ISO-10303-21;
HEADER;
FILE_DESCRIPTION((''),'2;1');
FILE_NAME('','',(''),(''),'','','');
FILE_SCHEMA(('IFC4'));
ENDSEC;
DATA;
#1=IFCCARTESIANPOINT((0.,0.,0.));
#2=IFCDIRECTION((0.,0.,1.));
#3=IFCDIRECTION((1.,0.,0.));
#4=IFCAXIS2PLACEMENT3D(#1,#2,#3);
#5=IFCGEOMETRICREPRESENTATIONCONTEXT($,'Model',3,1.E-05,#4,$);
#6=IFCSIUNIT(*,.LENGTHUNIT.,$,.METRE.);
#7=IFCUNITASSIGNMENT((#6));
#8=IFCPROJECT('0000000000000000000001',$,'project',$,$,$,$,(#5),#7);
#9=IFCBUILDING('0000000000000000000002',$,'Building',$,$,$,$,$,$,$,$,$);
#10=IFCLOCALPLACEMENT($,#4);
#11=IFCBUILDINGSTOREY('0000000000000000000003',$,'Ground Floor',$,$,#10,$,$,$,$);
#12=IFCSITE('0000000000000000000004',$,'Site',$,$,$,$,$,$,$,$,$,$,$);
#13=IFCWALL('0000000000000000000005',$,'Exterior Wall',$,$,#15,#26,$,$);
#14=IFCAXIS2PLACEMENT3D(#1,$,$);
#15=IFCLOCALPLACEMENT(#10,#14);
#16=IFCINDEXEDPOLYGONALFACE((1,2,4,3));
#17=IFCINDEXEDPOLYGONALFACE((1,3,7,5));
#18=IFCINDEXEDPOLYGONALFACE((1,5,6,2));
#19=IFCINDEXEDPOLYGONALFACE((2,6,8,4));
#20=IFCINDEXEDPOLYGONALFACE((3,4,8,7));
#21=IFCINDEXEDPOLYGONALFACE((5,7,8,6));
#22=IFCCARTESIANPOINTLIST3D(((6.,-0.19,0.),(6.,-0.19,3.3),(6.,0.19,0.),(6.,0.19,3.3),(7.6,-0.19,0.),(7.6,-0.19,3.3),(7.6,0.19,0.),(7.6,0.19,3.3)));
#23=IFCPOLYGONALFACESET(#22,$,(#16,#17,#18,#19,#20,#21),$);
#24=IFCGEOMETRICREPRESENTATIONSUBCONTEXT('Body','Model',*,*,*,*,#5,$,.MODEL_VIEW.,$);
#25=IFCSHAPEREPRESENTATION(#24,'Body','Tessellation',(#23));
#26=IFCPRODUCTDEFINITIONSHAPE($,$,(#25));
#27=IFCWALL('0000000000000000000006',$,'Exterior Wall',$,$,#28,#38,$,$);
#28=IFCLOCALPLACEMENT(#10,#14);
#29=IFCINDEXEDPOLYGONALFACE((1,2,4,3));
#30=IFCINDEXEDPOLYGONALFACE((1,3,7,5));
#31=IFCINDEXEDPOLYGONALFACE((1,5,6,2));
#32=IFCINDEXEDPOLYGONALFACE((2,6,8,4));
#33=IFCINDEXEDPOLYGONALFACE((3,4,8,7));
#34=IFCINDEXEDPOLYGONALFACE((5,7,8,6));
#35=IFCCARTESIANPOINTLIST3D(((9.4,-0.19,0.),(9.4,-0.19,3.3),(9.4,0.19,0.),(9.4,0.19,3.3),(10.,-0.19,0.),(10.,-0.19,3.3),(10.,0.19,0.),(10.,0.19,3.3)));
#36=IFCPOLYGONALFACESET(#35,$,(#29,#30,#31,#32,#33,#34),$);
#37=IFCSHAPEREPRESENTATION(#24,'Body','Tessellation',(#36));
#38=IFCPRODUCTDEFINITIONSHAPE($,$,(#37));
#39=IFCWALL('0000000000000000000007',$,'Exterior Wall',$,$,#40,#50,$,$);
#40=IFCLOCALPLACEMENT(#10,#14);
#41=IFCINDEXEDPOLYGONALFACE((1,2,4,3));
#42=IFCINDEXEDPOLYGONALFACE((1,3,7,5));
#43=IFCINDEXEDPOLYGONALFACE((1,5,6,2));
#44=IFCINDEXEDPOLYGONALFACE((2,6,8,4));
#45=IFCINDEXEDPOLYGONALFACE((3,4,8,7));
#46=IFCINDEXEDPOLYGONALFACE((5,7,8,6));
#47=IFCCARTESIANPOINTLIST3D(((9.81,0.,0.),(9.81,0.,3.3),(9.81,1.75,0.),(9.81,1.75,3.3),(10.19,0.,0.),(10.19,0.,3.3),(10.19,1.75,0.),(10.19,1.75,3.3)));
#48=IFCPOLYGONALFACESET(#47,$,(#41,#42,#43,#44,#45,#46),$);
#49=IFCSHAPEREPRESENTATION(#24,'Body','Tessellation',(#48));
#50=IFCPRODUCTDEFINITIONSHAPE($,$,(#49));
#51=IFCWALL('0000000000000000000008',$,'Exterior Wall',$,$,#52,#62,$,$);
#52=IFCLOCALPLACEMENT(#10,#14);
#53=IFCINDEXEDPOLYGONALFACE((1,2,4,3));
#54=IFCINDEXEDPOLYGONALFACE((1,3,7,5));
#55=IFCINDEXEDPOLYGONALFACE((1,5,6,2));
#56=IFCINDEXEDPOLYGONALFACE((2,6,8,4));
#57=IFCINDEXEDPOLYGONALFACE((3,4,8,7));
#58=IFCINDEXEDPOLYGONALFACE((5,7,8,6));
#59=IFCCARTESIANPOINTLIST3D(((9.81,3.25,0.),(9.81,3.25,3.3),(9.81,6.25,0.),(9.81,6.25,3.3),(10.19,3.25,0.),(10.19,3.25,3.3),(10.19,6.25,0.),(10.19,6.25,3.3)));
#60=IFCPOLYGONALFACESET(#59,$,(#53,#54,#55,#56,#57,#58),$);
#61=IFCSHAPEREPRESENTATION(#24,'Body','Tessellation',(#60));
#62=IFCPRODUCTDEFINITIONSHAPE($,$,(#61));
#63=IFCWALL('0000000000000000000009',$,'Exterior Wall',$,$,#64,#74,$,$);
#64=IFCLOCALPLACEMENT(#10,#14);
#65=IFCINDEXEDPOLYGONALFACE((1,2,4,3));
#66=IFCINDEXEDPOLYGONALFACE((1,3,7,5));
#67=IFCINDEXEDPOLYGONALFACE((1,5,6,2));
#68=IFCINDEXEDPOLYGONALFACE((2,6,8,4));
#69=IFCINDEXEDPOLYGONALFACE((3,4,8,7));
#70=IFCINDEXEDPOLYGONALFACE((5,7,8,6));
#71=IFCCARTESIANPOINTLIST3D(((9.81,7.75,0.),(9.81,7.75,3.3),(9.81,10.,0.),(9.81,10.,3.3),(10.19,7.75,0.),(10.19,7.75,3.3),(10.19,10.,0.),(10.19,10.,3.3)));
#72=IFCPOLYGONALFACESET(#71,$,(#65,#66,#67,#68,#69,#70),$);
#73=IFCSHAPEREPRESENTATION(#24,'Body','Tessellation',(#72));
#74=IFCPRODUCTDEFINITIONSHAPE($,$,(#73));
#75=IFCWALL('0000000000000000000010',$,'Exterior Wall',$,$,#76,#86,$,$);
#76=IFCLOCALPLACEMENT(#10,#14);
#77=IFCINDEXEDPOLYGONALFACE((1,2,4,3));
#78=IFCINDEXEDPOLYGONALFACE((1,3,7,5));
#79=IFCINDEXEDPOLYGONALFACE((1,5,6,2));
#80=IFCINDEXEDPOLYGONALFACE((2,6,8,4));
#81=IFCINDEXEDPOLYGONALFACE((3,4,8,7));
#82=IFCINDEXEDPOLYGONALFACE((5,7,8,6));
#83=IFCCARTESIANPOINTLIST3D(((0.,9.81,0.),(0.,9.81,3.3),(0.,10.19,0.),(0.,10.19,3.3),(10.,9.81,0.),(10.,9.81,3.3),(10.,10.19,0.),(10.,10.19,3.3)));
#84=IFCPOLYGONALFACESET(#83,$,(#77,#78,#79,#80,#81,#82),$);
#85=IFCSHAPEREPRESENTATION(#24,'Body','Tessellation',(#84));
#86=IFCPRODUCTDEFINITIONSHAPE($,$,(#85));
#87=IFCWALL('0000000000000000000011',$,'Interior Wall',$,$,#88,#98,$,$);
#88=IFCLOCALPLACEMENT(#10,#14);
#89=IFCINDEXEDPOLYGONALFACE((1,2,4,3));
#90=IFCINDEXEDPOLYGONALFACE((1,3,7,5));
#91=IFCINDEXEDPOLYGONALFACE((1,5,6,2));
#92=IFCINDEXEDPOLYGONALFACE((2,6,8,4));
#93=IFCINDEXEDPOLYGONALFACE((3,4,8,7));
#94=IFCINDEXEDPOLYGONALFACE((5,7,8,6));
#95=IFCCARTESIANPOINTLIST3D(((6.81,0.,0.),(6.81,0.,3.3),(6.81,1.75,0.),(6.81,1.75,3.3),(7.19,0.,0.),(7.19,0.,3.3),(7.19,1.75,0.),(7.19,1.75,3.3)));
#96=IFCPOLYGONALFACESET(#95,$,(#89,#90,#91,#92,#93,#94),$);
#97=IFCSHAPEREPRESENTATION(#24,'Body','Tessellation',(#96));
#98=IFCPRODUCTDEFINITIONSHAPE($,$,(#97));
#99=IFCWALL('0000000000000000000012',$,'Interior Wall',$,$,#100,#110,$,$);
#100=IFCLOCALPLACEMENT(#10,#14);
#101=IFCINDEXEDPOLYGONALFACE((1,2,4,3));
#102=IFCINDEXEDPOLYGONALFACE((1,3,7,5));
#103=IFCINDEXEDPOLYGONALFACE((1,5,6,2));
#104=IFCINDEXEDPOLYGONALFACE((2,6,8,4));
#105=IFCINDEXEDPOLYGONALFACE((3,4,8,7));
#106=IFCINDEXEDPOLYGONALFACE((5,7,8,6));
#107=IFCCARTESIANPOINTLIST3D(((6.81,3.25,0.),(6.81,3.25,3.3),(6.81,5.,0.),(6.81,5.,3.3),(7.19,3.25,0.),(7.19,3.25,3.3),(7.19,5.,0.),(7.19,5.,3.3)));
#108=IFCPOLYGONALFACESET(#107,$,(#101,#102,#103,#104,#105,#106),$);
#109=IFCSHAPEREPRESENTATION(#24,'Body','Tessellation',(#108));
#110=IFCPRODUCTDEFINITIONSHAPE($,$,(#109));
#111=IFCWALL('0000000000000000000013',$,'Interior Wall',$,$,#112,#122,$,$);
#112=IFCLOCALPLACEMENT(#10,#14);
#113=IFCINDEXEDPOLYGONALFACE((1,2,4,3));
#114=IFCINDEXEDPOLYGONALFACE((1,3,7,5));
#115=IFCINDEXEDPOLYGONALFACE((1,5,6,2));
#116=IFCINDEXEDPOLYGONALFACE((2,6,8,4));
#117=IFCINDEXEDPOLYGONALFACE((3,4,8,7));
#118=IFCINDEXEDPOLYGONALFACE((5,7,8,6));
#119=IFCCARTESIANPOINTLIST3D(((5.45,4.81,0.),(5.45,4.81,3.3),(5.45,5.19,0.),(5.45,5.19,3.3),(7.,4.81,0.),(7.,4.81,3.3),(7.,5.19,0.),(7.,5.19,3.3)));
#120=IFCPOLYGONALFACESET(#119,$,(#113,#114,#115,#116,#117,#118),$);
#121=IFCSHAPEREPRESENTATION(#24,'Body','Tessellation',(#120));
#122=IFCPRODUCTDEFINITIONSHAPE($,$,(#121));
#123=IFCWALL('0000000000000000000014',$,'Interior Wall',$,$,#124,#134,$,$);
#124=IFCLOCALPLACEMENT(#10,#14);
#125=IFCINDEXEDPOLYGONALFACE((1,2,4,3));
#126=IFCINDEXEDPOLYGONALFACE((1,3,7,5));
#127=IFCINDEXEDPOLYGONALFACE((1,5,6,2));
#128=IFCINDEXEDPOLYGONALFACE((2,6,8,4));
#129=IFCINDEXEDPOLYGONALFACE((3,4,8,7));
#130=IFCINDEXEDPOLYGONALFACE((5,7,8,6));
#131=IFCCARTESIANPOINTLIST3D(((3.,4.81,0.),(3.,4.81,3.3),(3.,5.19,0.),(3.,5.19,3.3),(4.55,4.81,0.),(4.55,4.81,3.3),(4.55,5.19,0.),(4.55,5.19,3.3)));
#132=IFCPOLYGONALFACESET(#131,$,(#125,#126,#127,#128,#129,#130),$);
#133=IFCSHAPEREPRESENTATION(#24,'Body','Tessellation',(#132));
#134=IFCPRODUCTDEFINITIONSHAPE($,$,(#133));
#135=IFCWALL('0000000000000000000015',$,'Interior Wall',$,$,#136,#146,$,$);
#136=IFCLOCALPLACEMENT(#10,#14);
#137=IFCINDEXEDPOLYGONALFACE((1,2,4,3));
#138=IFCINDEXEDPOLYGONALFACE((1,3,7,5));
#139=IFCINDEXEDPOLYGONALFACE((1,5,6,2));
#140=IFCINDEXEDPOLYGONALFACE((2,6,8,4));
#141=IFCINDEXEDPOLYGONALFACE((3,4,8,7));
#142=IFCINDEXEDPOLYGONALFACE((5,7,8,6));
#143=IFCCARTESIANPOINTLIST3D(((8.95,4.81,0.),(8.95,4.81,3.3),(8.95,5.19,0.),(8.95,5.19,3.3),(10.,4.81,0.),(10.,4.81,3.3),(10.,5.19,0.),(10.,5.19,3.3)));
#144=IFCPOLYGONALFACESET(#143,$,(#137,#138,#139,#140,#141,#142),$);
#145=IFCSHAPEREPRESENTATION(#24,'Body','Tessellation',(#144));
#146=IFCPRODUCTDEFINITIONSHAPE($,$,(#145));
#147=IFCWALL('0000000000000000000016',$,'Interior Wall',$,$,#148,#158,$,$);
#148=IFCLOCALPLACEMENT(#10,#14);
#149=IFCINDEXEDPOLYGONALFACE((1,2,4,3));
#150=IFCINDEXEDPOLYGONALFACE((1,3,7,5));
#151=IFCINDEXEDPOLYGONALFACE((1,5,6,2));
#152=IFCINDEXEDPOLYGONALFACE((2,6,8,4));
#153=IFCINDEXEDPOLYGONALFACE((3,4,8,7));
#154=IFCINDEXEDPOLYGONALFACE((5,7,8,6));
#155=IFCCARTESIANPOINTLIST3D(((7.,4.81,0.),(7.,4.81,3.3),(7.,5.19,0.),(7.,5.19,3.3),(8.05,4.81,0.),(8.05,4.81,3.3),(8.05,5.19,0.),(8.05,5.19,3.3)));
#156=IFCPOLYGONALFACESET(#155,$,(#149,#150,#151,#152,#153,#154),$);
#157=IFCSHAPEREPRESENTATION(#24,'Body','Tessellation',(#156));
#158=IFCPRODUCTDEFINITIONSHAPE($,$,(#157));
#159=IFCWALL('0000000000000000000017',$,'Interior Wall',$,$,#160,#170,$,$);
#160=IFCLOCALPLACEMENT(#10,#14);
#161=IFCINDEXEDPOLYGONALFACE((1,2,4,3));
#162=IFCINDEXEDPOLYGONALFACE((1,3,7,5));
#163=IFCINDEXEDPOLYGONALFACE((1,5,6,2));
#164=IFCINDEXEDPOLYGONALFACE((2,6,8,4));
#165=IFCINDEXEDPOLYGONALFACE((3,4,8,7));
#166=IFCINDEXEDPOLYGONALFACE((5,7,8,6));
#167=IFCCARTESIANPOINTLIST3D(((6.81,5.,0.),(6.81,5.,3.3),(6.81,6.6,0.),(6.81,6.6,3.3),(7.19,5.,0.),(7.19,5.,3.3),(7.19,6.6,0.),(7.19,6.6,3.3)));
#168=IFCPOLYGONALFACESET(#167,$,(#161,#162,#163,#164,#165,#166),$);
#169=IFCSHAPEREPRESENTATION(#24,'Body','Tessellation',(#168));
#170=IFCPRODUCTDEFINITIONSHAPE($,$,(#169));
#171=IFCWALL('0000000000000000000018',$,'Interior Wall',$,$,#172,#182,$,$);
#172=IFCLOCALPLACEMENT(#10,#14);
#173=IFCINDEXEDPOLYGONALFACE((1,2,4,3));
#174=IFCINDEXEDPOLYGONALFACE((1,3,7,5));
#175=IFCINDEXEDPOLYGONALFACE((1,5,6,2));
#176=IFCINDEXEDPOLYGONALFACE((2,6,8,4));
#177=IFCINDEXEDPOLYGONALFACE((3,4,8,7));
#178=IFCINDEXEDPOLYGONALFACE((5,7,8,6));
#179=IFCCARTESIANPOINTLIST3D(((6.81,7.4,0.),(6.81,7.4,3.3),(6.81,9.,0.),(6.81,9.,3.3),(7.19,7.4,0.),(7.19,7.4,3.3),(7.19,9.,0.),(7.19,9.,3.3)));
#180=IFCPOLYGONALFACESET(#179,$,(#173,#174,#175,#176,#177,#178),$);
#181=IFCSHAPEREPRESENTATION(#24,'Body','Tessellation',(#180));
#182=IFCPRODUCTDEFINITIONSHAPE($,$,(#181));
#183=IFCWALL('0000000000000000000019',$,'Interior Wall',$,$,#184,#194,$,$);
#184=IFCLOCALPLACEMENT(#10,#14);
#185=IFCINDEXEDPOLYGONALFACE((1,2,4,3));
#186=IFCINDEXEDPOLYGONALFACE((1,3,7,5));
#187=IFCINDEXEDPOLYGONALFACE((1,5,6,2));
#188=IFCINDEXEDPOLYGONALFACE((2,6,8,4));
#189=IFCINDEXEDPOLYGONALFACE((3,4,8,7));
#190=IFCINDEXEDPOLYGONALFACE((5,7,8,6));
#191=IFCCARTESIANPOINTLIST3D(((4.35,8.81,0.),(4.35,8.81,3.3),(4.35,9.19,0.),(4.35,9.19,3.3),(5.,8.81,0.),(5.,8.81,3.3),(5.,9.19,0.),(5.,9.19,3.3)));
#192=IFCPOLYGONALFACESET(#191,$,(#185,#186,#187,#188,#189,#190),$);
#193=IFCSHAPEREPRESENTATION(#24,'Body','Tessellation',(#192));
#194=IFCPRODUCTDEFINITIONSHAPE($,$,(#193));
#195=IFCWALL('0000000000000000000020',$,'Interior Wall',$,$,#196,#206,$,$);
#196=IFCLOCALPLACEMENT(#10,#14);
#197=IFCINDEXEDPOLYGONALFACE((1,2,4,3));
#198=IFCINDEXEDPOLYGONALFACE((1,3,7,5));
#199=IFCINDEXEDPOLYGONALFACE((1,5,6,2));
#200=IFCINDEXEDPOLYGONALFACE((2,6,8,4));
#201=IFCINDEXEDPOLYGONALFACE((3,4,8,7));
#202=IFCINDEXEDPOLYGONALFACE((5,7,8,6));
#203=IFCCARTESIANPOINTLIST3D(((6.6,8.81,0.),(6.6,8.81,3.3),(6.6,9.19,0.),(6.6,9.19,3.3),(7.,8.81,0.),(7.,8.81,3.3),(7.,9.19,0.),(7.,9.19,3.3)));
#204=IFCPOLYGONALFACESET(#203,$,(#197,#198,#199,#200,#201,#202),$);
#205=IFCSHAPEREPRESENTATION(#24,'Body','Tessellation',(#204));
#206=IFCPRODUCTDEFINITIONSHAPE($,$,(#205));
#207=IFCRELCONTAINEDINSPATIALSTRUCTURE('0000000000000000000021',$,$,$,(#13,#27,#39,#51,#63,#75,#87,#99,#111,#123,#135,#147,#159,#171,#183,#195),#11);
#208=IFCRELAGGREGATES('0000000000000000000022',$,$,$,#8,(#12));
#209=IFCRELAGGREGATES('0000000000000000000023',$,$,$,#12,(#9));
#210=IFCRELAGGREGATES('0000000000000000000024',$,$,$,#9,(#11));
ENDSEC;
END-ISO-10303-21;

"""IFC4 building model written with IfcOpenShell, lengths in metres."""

from ifc_helpers import new_model, si_unit, frame, origin_with_axes, place, context, subcontext, project, spatial, indexed_curve, outline, extrude, element, save


model = new_model("IFC4")

# Units and contexts
model_context = context("Model", 3, precision=1e-05, world=origin_with_axes())
body_context = subcontext(model_context, "Body", "Model", "MODEL_VIEW")
ifc_project = project(units=[si_unit("LENGTHUNIT", "METRE")], contexts=[model_context])

# Site, building, storey
site = spatial("IfcSite", under=ifc_project, Name="Site")
building = spatial("IfcBuilding", under=site, Name="Building")
storey_placement = place(None, origin_with_axes())
storey = spatial("IfcBuildingStorey", under=building, at=storey_placement, Name="Ground Floor")

# Walls
wall_1_placement = place(storey_placement, frame((6.0, 0.0, 0.0), z_axis=(0.0, 0.0, 1.0), x_axis=(1.0, 0.0, 0.0)))
element("IfcWall", 1, at=wall_1_placement, inside=storey, Name="Exterior Wall", context=body_context, shape_type="SweptSolid", body=[
    extrude(outline(indexed_curve([(0.0, 0.0), (0.0, 0.38), (1.6, 0.38), (1.6, 0.0), (0.0, 0.0)], self_intersect=False)), frame((0.0, -0.19, 0.0), z_axis=(0.0, 0.0, 1.0), x_axis=(1.0, 0.0, 0.0)), (0.0, 0.0, 1.0), 3.3),
])
wall_2_placement = place(storey_placement, frame((9.4, 0.0, 0.0), z_axis=(0.0, 0.0, 1.0), x_axis=(1.0, 0.0, 0.0)))
element("IfcWall", 2, at=wall_2_placement, inside=storey, Name="Exterior Wall", context=body_context, shape_type="SweptSolid", body=[
    extrude(outline(indexed_curve([(0.0, 0.0), (0.0, 0.38), (0.6, 0.38), (0.6, 0.0), (0.0, 0.0)], self_intersect=False)), frame((0.0, -0.19, 0.0), z_axis=(0.0, 0.0, 1.0), x_axis=(1.0, 0.0, 0.0)), (0.0, 0.0, 1.0), 3.3),
])
wall_3_placement = place(storey_placement, frame((10.0, 0.0, 0.0), z_axis=(0.0, 0.0, 1.0), x_axis=(0.0, 1.0, 0.0)))
element("IfcWall", 3, at=wall_3_placement, inside=storey, Name="Exterior Wall", context=body_context, shape_type="SweptSolid", body=[
    extrude(outline(indexed_curve([(0.0, 0.0), (0.0, 0.38), (1.75, 0.38), (1.75, 0.0), (0.0, 0.0)], self_intersect=False)), frame((0.0, -0.19, 0.0), z_axis=(0.0, 0.0, 1.0), x_axis=(1.0, 0.0, 0.0)), (0.0, 0.0, 1.0), 3.3),
])
wall_4_placement = place(storey_placement, frame((10.0, 3.25, 0.0), z_axis=(0.0, 0.0, 1.0), x_axis=(0.0, 1.0, 0.0)))
element("IfcWall", 4, at=wall_4_placement, inside=storey, Name="Exterior Wall", context=body_context, shape_type="SweptSolid", body=[
    extrude(outline(indexed_curve([(0.0, 0.0), (0.0, 0.38), (3.0, 0.38), (3.0, 0.0), (0.0, 0.0)], self_intersect=False)), frame((0.0, -0.19, 0.0), z_axis=(0.0, 0.0, 1.0), x_axis=(1.0, 0.0, 0.0)), (0.0, 0.0, 1.0), 3.3),
])
wall_5_placement = place(storey_placement, frame((10.0, 7.75, 0.0), z_axis=(0.0, 0.0, 1.0), x_axis=(0.0, 1.0, 0.0)))
element("IfcWall", 5, at=wall_5_placement, inside=storey, Name="Exterior Wall", context=body_context, shape_type="SweptSolid", body=[
    extrude(outline(indexed_curve([(0.0, 0.0), (0.0, 0.38), (2.25, 0.38), (2.25, 0.0), (0.0, 0.0)], self_intersect=False)), frame((0.0, -0.19, 0.0), z_axis=(0.0, 0.0, 1.0), x_axis=(1.0, 0.0, 0.0)), (0.0, 0.0, 1.0), 3.3),
])
wall_6_placement = place(storey_placement, frame((10.0, 10.0, 0.0), z_axis=(0.0, 0.0, 1.0), x_axis=(-1.0, 0.0, 0.0)))
element("IfcWall", 6, at=wall_6_placement, inside=storey, Name="Exterior Wall", context=body_context, shape_type="SweptSolid", body=[
    extrude(outline(indexed_curve([(0.0, 0.0), (0.0, 0.38), (10.0, 0.38), (10.0, 0.0), (0.0, 0.0)], self_intersect=False)), frame((0.0, -0.19, 0.0), z_axis=(0.0, 0.0, 1.0), x_axis=(1.0, 0.0, 0.0)), (0.0, 0.0, 1.0), 3.3),
])
for number, where, z_axis, x_axis, name in (
    (7, (7.0, 0.0, 0.0), (0.0, 0.0, 1.0), (0.0, 1.0, 0.0), "Interior Wall"),
    (8, (7.0, 3.25, 0.0), (0.0, 0.0, 1.0), (0.0, 1.0, 0.0), "Interior Wall"),
):
    element("IfcWall", number, at=place(storey_placement, frame(where, z_axis=z_axis, x_axis=x_axis)), inside=storey, Name=name, context=body_context, shape_type="SweptSolid", body=[
        extrude(outline(indexed_curve([(0.0, 0.0), (0.0, 0.38), (1.75, 0.38), (1.75, 0.0), (0.0, 0.0)], self_intersect=False)), frame((0.0, -0.19, 0.0), z_axis=(0.0, 0.0, 1.0), x_axis=(1.0, 0.0, 0.0)), (0.0, 0.0, 1.0), 3.3),
    ])
for number, where, z_axis, x_axis, name in (
    (9, (7.0, 5.0, 0.0), (0.0, 0.0, 1.0), (-1.0, 0.0, 0.0), "Interior Wall"),
    (10, (4.55, 5.0, 0.0), (0.0, 0.0, 1.0), (-1.0, 0.0, 0.0), "Interior Wall"),
):
    element("IfcWall", number, at=place(storey_placement, frame(where, z_axis=z_axis, x_axis=x_axis)), inside=storey, Name=name, context=body_context, shape_type="SweptSolid", body=[
        extrude(outline(indexed_curve([(0.0, 0.0), (0.0, 0.38), (1.55, 0.38), (1.55, 0.0), (0.0, 0.0)], self_intersect=False)), frame((0.0, -0.19, 0.0), z_axis=(0.0, 0.0, 1.0), x_axis=(1.0, 0.0, 0.0)), (0.0, 0.0, 1.0), 3.3),
    ])
for number, where, z_axis, x_axis, name in (
    (11, (10.0, 5.0, 0.0), (0.0, 0.0, 1.0), (-1.0, 0.0, 0.0), "Interior Wall"),
    (12, (8.05, 5.0, 0.0), (0.0, 0.0, 1.0), (-1.0, 0.0, 0.0), "Interior Wall"),
):
    element("IfcWall", number, at=place(storey_placement, frame(where, z_axis=z_axis, x_axis=x_axis)), inside=storey, Name=name, context=body_context, shape_type="SweptSolid", body=[
        extrude(outline(indexed_curve([(0.0, 0.0), (0.0, 0.38), (1.05, 0.38), (1.05, 0.0), (0.0, 0.0)], self_intersect=False)), frame((0.0, -0.19, 0.0), z_axis=(0.0, 0.0, 1.0), x_axis=(1.0, 0.0, 0.0)), (0.0, 0.0, 1.0), 3.3),
    ])
for number, where, z_axis, x_axis, name in (
    (13, (7.0, 5.0, 0.0), (0.0, 0.0, 1.0), (0.0, 1.0, 0.0), "Interior Wall"),
    (14, (7.0, 7.4, 0.0), (0.0, 0.0, 1.0), (0.0, 1.0, 0.0), "Interior Wall"),
):
    element("IfcWall", number, at=place(storey_placement, frame(where, z_axis=z_axis, x_axis=x_axis)), inside=storey, Name=name, context=body_context, shape_type="SweptSolid", body=[
        extrude(outline(indexed_curve([(0.0, 0.0), (0.0, 0.38), (1.6, 0.38), (1.6, 0.0), (0.0, 0.0)], self_intersect=False)), frame((0.0, -0.19, 0.0), z_axis=(0.0, 0.0, 1.0), x_axis=(1.0, 0.0, 0.0)), (0.0, 0.0, 1.0), 3.3),
    ])
wall_7_placement = place(storey_placement, frame((5.0, 9.0, 0.0), z_axis=(0.0, 0.0, 1.0), x_axis=(-1.0, 0.0, 0.0)))
element("IfcWall", 15, at=wall_7_placement, inside=storey, Name="Interior Wall", context=body_context, shape_type="SweptSolid", body=[
    extrude(outline(indexed_curve([(0.0, 0.0), (0.0, 0.38), (0.65, 0.38), (0.65, 0.0), (0.0, 0.0)], self_intersect=False)), frame((0.0, -0.19, 0.0), z_axis=(0.0, 0.0, 1.0), x_axis=(1.0, 0.0, 0.0)), (0.0, 0.0, 1.0), 3.3),
])
for number, where, z_axis, x_axis, name in (
    (16, (7.0, 9.0, 0.0), (0.0, 0.0, 1.0), (-1.0, 0.0, 0.0), "Interior Wall"),
):
    element("IfcWall", number, at=place(storey_placement, frame(where, z_axis=z_axis, x_axis=x_axis)), inside=storey, Name=name, context=body_context, shape_type="SweptSolid", body=[
        extrude(outline(indexed_curve([(0.0, 0.0), (0.0, 0.38), (0.4, 0.38), (0.4, 0.0), (0.0, 0.0)], self_intersect=False)), frame((0.0, -0.19, 0.0), z_axis=(0.0, 0.0, 1.0), x_axis=(1.0, 0.0, 0.0)), (0.0, 0.0, 1.0), 3.3),
    ])

save(model, "model.ifc")
